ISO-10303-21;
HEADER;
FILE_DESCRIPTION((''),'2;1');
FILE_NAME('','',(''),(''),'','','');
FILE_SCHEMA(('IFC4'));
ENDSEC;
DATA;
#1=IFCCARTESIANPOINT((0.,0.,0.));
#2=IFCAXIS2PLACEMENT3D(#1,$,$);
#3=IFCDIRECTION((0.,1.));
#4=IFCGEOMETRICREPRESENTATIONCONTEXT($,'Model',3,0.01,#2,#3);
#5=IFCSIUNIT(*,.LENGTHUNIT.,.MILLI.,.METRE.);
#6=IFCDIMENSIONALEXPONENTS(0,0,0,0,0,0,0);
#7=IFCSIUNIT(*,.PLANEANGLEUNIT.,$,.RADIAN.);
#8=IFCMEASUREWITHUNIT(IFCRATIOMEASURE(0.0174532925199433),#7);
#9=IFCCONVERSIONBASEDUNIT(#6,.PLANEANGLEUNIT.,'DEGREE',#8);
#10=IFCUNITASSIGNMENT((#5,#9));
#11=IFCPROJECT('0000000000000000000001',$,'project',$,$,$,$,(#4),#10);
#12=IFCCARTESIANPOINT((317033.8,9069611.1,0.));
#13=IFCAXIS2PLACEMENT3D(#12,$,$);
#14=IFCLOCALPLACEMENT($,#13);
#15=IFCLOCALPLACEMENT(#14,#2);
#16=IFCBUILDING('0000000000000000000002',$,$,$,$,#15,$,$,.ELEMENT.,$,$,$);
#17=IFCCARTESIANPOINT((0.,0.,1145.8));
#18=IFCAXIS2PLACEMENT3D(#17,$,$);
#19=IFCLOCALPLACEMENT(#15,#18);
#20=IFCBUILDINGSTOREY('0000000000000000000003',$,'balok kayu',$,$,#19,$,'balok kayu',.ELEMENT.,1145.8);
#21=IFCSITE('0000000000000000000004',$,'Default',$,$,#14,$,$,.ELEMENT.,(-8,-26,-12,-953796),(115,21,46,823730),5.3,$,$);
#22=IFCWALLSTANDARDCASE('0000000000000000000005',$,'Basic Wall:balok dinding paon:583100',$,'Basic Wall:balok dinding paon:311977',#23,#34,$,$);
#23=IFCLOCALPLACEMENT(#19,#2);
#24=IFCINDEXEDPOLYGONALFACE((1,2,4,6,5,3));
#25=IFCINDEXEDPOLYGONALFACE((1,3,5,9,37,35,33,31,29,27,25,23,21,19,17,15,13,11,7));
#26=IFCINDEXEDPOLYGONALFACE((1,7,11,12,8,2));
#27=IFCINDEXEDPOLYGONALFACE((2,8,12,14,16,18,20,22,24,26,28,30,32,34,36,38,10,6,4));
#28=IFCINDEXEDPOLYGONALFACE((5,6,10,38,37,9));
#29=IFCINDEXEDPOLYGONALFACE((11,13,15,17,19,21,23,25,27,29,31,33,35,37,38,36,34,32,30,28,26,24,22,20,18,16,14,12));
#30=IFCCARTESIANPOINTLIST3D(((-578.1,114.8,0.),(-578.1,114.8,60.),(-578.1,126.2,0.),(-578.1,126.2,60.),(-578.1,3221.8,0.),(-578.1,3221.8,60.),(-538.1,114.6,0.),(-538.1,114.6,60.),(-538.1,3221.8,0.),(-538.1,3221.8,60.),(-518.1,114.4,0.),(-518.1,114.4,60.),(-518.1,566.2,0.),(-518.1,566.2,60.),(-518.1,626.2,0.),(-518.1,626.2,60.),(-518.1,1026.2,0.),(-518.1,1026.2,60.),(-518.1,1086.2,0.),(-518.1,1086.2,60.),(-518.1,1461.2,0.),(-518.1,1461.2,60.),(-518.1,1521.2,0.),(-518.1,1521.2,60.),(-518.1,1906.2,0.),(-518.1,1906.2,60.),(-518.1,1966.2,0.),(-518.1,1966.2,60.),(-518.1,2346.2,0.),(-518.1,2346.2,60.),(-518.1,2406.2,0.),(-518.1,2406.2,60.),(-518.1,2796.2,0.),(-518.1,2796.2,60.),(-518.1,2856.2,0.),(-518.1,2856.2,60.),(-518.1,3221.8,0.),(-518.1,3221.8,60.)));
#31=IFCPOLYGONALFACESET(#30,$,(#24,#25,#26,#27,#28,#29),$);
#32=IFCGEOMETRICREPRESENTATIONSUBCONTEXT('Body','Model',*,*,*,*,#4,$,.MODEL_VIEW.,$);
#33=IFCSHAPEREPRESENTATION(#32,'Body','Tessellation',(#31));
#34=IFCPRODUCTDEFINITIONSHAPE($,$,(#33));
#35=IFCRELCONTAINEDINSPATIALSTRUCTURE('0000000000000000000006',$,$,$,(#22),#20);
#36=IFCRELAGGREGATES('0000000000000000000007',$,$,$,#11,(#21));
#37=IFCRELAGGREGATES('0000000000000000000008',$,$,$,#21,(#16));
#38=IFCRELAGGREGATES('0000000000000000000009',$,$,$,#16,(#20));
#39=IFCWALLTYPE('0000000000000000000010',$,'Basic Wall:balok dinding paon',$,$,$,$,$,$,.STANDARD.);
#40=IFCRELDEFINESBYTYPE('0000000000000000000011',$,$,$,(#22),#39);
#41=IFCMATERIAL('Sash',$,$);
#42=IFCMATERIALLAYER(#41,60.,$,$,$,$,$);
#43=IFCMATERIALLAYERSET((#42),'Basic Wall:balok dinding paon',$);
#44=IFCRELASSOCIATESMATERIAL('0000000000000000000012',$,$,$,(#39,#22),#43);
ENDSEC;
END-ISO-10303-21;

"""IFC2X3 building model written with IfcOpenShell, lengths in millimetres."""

from ifc_helpers import new_model, entity, si_unit, converted_unit, direction, frame, origin, place, context, subcontext, project, spatial, polyline, outline, extrude, material, layer, layer_set, layer_usage, type_object, element, save


model = new_model("IFC2X3")

# Units and contexts
model_context = context("Model", 3, precision=0.01, world=origin(), true_north=direction((0.0, 1.0)))
body_context = subcontext(model_context, "Body", "Model", "MODEL_VIEW")
ifc_project = project(units=[si_unit("LENGTHUNIT", "METRE", prefix="MILLI"), converted_unit("PLANEANGLEUNIT", "DEGREE", entity("IfcRatioMeasure", 0.0174532925199433), si_unit("PLANEANGLEUNIT", "RADIAN"), dimensions=[0, 0, 0, 0, 0, 0, 0])], contexts=[model_context])

# Site, building, storey
site_placement = place(None, frame((317033.8, 9069611.1, 0.0)))
site = spatial("IfcSite", under=ifc_project, at=site_placement, Name="Default", CompositionType="ELEMENT", RefLatitude=(-8, -26, -12, -953796), RefLongitude=(115, 21, 46, 823730), RefElevation=5.3)
building_placement = place(site_placement, origin())
building = spatial("IfcBuilding", under=site, at=building_placement, CompositionType="ELEMENT")
storey_placement = place(building_placement, frame((0.0, 0.0, 1145.8)))
storey = spatial("IfcBuildingStorey", under=building, at=storey_placement, Name="balok kayu", LongName="balok kayu", CompositionType="ELEMENT", Elevation=1145.8)

# Wall
ifc_material_1 = material(Name="Sash")
ifc_layer_1 = layer(ifc_material_1, 60.0)
ifc_layer_set_1 = layer_set([ifc_layer_1], Name="Basic Wall:balok dinding paon")
wall_type_1 = type_object("IfcWallType", Name="Basic Wall:balok dinding paon", PredefinedType="STANDARD", material=ifc_layer_set_1)
ifc_layer_usage_1 = layer_usage(ifc_layer_set_1, "AXIS2", "NEGATIVE", 30.0)
wall_1_placement = place(storey_placement, frame((-548.1, 3221.8, 0.0), z_axis=(0.0, 0.0, 1.0), x_axis=(0.0, -1.0, 0.0)))
element("IfcWallStandardCase", 1, at=wall_1_placement, inside=storey, type_object=wall_type_1, material=ifc_layer_usage_1, Name="Basic Wall:balok dinding paon:583100", ObjectType="Basic Wall:balok dinding paon:311977", context=body_context, shape_type="SweptSolid", body=[
    extrude(outline(polyline([(3107.0, -30.0), (3107.2, 10.0), (3107.4, 30.0), (2655.6, 30.0), (2595.6, 30.0), (2195.6, 30.0), (2135.6, 30.0), (1760.6, 30.0), (1700.6, 30.0), (1315.6, 30.0), (1255.6, 30.0), (875.6, 30.0), (815.6, 30.0), (425.6, 30.0), (365.6, 30.0), (0.0, 30.0), (0.0, 10.0), (0.0, -30.0), (3095.6, -30.0), (3107.0, -30.0)])), origin(), (0.0, 0.0, 1.0), 60.0),
])

save(model, "model.ifc")
